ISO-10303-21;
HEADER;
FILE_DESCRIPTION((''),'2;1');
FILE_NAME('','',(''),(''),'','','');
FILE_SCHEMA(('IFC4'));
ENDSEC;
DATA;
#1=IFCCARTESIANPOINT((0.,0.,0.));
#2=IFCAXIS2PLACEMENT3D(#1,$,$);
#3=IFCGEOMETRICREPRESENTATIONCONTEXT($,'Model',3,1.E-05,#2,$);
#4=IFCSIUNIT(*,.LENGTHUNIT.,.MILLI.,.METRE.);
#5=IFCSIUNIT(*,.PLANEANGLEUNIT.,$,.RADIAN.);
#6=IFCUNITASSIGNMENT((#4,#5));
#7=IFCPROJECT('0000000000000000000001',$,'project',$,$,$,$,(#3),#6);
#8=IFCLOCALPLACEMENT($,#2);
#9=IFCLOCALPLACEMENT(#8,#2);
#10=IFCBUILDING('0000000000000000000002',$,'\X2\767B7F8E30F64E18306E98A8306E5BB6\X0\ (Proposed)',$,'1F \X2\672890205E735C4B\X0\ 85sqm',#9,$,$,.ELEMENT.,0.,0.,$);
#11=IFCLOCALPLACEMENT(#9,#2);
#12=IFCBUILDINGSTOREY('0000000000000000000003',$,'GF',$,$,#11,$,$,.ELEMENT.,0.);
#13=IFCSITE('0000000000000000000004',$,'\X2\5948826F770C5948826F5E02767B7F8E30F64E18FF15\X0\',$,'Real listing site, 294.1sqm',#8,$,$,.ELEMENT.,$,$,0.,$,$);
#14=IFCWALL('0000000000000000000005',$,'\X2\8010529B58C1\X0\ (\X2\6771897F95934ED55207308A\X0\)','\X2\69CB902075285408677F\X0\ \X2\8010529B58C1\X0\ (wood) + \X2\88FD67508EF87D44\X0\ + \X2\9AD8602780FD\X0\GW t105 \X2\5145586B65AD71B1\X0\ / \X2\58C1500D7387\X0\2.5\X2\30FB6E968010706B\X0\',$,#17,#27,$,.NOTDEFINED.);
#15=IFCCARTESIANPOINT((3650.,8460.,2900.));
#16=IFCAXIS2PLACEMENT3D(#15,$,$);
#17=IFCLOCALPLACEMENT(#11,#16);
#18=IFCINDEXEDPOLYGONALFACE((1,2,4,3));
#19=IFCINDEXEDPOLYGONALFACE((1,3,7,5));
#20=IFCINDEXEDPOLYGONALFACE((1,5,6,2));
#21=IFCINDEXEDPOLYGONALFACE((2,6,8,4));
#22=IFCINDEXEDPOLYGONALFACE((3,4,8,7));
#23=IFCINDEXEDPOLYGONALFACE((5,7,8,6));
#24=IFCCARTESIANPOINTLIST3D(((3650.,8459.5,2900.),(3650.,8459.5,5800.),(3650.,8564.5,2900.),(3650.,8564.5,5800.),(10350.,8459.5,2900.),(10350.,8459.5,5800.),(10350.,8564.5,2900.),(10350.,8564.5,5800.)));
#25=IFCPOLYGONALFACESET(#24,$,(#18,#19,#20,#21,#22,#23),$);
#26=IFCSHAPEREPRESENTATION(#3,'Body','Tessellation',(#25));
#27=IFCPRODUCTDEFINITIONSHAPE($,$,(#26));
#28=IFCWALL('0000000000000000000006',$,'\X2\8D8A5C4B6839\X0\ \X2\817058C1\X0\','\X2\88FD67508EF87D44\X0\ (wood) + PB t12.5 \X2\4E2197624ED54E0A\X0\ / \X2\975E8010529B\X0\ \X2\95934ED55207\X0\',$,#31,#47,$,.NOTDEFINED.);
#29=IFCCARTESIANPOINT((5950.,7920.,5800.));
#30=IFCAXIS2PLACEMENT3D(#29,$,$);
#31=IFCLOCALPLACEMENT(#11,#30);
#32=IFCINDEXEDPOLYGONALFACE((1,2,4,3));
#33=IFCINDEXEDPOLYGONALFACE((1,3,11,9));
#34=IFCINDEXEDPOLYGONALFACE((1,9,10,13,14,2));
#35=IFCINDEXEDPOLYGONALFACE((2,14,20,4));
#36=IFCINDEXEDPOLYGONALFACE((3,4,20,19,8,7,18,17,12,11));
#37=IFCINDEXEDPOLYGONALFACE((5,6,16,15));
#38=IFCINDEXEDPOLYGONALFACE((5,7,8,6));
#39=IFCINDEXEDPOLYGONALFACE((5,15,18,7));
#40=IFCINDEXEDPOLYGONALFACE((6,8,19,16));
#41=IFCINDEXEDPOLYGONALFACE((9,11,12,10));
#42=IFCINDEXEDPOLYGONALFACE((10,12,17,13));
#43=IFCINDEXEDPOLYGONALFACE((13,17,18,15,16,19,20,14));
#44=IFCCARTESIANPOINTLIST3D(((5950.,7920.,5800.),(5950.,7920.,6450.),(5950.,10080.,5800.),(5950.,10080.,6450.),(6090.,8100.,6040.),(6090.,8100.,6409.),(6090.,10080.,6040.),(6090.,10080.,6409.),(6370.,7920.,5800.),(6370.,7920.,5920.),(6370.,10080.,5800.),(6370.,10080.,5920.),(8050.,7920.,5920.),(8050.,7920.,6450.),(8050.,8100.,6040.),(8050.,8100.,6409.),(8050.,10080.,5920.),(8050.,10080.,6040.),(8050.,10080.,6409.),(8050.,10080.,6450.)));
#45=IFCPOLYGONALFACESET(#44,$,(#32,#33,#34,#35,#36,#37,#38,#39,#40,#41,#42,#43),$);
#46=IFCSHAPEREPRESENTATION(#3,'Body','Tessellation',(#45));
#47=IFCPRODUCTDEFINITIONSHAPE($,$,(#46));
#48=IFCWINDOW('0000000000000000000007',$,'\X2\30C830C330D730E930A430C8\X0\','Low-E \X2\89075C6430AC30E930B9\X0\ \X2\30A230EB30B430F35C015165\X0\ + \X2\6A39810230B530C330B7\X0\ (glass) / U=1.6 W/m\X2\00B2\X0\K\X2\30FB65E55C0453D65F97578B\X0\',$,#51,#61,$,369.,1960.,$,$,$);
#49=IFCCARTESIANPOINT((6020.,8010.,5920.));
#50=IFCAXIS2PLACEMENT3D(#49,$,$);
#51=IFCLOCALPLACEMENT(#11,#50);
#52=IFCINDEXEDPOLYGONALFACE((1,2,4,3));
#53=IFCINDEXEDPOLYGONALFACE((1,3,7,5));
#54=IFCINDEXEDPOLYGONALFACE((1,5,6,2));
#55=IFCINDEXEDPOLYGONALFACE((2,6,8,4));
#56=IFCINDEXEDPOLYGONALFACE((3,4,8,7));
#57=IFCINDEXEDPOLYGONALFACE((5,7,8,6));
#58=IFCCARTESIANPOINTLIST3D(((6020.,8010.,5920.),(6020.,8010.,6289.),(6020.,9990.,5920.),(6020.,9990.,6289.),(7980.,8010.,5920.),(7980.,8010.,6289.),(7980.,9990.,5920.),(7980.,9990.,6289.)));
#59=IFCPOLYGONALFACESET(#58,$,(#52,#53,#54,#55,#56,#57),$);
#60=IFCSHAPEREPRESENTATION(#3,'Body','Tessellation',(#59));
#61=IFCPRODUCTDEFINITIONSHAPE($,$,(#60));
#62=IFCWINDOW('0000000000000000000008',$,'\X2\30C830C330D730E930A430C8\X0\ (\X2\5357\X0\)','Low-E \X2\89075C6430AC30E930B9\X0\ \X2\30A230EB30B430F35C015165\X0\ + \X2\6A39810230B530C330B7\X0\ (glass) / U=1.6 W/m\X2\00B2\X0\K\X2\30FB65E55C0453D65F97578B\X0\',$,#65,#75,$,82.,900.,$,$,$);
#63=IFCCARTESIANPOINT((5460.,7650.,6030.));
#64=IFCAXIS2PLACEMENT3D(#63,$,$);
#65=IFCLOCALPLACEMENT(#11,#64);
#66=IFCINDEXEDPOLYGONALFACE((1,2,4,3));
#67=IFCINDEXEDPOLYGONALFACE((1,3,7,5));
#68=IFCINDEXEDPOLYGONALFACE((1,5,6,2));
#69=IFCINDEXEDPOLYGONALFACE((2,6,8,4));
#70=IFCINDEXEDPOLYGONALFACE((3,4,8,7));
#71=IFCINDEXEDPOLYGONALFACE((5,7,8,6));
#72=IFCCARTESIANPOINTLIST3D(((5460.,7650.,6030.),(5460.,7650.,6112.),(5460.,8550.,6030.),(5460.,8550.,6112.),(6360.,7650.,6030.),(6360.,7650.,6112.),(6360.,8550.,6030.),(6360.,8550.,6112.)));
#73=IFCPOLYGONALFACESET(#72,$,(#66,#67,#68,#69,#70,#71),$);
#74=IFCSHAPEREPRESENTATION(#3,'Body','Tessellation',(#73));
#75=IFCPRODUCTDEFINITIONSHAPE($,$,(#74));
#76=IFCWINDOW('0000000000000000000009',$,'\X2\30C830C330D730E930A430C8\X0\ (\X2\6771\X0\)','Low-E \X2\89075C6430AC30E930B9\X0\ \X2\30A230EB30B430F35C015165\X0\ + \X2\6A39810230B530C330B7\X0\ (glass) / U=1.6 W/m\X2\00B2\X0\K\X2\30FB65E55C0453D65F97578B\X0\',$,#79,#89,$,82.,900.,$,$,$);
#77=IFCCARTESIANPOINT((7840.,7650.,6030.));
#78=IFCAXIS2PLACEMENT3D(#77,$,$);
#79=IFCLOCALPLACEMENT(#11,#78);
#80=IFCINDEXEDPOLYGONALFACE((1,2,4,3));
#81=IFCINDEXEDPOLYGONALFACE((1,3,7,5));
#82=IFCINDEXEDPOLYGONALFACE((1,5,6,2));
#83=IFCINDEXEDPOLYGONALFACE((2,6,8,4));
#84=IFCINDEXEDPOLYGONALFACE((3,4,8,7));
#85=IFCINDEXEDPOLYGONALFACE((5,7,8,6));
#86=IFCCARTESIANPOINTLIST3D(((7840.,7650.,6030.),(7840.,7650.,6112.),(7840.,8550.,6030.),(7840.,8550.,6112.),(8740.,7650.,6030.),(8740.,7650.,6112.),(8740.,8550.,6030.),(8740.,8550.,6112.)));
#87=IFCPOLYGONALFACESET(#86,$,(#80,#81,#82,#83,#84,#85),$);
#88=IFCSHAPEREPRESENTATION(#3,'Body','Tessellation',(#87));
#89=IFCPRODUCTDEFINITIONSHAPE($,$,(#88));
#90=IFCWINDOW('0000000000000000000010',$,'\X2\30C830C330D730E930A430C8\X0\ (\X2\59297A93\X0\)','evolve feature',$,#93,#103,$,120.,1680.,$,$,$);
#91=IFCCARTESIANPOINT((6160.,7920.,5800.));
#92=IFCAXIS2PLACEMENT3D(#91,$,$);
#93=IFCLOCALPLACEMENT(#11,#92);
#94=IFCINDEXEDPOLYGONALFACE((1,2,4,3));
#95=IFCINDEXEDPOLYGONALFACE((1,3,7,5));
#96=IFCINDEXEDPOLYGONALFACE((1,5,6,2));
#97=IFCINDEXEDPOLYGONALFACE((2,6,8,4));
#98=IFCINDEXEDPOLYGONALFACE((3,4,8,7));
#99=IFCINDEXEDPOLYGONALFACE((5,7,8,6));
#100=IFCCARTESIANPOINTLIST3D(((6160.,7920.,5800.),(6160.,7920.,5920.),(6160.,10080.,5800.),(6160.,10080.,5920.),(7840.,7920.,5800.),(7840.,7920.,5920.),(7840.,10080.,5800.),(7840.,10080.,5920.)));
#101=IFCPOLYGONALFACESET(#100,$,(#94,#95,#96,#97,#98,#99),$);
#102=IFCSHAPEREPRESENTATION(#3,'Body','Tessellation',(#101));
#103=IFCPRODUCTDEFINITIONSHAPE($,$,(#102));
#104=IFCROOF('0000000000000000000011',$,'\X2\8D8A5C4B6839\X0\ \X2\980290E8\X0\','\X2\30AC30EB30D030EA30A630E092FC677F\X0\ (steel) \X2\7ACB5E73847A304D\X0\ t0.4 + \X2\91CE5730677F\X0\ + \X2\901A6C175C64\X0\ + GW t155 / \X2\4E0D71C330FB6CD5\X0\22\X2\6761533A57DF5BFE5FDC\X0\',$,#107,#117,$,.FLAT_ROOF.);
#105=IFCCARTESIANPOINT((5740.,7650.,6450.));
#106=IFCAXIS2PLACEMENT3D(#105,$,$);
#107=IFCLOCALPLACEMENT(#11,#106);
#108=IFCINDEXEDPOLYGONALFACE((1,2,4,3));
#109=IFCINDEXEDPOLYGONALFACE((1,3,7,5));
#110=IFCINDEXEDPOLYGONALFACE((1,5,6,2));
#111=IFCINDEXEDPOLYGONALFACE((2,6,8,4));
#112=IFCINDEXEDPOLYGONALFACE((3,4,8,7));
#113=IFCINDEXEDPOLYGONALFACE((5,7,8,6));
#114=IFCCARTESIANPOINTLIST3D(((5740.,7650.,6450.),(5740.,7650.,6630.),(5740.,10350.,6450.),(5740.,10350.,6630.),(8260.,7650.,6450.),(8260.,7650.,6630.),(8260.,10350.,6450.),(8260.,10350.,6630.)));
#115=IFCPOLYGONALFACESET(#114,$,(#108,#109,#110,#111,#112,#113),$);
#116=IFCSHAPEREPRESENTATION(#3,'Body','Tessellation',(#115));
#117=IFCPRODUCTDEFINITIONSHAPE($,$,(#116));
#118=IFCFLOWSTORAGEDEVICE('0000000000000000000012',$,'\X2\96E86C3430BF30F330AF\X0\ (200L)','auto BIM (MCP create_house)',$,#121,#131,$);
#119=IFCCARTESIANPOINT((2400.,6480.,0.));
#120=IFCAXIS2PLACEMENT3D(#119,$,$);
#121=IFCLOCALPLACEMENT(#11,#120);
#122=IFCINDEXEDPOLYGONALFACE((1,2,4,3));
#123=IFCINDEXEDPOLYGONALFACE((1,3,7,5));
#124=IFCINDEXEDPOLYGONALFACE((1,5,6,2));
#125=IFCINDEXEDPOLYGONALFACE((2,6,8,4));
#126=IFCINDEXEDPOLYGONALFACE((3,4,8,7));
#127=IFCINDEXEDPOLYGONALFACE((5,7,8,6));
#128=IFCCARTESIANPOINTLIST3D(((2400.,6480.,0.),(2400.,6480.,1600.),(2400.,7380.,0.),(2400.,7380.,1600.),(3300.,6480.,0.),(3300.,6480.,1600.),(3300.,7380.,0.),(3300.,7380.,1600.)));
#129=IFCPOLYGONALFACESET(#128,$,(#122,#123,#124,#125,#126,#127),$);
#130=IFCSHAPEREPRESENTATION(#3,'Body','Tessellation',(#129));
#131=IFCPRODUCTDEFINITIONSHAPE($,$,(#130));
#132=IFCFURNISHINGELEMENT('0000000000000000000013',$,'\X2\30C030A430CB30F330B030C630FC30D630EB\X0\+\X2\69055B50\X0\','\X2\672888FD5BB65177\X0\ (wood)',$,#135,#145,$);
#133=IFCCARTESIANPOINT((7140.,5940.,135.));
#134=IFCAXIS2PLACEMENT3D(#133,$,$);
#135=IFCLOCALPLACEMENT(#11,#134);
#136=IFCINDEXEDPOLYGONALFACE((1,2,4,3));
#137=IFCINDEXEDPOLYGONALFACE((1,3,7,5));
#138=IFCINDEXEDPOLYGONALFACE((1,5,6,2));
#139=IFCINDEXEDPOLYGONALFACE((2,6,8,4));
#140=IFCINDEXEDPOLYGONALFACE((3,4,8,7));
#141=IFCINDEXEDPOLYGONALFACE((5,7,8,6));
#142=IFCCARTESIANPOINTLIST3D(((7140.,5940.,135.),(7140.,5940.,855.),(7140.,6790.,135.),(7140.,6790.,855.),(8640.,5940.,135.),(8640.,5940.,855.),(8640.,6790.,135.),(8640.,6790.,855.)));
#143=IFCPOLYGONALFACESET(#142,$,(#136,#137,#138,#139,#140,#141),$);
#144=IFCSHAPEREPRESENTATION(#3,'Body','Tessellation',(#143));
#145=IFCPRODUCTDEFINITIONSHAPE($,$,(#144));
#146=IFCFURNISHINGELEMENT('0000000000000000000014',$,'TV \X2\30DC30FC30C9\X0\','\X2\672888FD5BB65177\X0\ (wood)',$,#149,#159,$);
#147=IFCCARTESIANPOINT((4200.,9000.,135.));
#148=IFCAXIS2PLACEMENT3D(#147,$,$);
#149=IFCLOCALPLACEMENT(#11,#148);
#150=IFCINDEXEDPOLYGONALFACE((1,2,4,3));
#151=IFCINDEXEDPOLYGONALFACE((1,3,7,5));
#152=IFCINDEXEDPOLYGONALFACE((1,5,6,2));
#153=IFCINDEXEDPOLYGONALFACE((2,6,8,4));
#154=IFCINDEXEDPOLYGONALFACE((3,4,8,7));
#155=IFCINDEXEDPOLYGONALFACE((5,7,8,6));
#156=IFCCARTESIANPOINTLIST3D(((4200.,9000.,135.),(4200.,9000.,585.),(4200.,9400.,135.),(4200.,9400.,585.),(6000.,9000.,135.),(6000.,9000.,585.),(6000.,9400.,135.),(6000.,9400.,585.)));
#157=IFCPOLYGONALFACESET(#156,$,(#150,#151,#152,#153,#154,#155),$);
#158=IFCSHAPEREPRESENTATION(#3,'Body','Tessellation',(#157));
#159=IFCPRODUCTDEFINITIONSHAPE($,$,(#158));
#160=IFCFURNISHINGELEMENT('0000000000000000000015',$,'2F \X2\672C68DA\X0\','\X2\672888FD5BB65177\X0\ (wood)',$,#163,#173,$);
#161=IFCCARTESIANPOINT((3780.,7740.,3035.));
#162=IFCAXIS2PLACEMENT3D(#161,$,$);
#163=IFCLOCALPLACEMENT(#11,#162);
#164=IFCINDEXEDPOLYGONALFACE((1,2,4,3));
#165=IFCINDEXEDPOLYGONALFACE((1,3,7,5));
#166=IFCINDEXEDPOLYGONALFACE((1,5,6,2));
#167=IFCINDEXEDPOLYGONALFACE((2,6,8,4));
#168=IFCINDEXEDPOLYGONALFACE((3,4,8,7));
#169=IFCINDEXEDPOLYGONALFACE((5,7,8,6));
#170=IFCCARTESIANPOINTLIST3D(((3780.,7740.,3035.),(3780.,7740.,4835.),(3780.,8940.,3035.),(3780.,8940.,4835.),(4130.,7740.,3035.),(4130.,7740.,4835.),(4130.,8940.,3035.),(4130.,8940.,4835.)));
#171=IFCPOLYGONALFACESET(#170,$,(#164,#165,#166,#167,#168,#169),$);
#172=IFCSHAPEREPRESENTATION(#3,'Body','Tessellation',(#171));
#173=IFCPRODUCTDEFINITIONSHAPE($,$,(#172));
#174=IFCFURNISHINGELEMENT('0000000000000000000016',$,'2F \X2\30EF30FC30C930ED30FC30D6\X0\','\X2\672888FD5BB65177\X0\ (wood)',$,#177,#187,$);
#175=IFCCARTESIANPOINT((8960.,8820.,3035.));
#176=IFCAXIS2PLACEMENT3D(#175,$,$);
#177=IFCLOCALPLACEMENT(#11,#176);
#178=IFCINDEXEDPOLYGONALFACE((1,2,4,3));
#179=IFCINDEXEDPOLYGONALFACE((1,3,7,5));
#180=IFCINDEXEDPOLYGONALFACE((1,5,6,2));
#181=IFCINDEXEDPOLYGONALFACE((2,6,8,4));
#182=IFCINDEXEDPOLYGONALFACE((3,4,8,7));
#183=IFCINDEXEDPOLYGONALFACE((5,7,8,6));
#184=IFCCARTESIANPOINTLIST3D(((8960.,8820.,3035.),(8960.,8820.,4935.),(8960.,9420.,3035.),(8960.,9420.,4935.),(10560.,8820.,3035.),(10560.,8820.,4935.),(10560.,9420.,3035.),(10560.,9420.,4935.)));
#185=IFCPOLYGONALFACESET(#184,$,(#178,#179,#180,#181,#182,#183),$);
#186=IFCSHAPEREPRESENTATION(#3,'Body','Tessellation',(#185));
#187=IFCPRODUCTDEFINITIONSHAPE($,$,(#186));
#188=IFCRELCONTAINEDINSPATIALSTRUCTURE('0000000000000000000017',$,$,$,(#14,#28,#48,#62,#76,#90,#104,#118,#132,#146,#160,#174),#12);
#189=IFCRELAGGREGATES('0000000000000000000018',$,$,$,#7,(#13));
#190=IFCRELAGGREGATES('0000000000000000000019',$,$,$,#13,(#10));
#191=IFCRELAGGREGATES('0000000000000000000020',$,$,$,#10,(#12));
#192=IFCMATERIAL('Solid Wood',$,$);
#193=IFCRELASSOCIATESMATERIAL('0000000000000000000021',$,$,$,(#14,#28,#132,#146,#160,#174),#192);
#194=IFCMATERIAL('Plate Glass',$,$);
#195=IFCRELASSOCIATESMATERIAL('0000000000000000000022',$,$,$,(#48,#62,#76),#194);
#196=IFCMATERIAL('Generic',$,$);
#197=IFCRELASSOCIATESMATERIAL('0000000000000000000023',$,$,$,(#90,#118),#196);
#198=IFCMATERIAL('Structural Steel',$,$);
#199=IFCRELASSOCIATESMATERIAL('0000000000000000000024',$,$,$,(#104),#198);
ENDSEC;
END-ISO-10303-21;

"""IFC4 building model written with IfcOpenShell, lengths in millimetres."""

from ifc_helpers import new_model, si_unit, frame, frame_2d, origin, place, context, project, spatial, rectangle, extrude, material, element, fill, save


model = new_model("IFC4")

# Units and contexts
model_context = context("Model", 3, precision=1e-05, world=origin())
ifc_project = project(units=[si_unit("LENGTHUNIT", "METRE", prefix="MILLI"), si_unit("PLANEANGLEUNIT", "RADIAN")], contexts=[model_context])

# Site, building, storey
site_placement = place(None, origin())
site = spatial("IfcSite", under=ifc_project, at=site_placement, Name="奈良県奈良市登美ヶ丘５", ObjectType="Real listing site, 294.1sqm", CompositionType="ELEMENT", RefElevation=0.0)
building_placement = place(site_placement, origin())
building = spatial("IfcBuilding", under=site, at=building_placement, Name="登美ヶ丘の風の家 (Proposed)", ObjectType="1F 木造平屋 85sqm", CompositionType="ELEMENT", ElevationOfRefHeight=0.0, ElevationOfTerrain=0.0)
storey_placement = place(building_placement, origin())
storey = spatial("IfcBuildingStorey", under=building, at=storey_placement, Name="GF", CompositionType="ELEMENT", Elevation=0.0)

# Wall
ifc_material_1 = material(Name="Solid Wood")
wall_1_placement = place(storey_placement, frame((3650.0, 8460.0, 2900.0)))
element("IfcWall", 1, at=wall_1_placement, inside=storey, material=ifc_material_1, Name="耐力壁 (東西間仕切り)", Description="構造用合板 耐力壁 (wood) + 製材軸組 + 高性能GW t105 充填断熱 / 壁倍率2.5・準耐火", PredefinedType="NOTDEFINED", context=model_context, shape_type="SweptSolid", body=[
    extrude(rectangle(XDim=6700.0, YDim=105.0, at=frame_2d((3350.0, 52.0))), frame((3650.0, 8460.0, 2900.0)), (0.0, 0.0, 1.0), 2900.0),
])

# Wall, openings, windows
wall_2_placement = place(storey_placement, frame((5950.0, 7920.0, 5800.0)))
wall_2 = element("IfcWall", 2, at=wall_2_placement, inside=storey, material=ifc_material_1, Name="越屋根 腰壁", Description="製材軸組 (wood) + PB t12.5 両面仕上 / 非耐力 間仕切", PredefinedType="NOTDEFINED", context=model_context, shape_type="SweptSolid", body=[
    extrude(rectangle(XDim=2100.0, YDim=2160.0, at=frame_2d((1050.0, 1080.0))), frame((5950.0, 7920.0, 5800.0)), (0.0, 0.0, 1.0), 650.0),
])
opening_1_placement = place(storey_placement, frame((6020.0, 8010.0, 5920.0)))
opening_1 = element("IfcOpeningElement", 3, at=opening_1_placement, cuts=wall_2, PredefinedType="NOTDEFINED", context=model_context, shape_type="SweptSolid", body=[
    extrude(rectangle(XDim=1960.0, YDim=1980.0, at=frame_2d((980.0, 990.0))), frame((6020.0, 8010.0, 5920.0)), (0.0, 0.0, 1.0), 369.0),
])
opening_2_placement = place(storey_placement, frame((5460.0, 7650.0, 6030.0)))
opening_2 = element("IfcOpeningElement", 4, at=opening_2_placement, cuts=wall_2, PredefinedType="NOTDEFINED", context=model_context, shape_type="SweptSolid", body=[
    extrude(rectangle(XDim=900.0, YDim=900.0, at=frame_2d((450.0, 450.0))), frame((5460.0, 7650.0, 6030.0)), (0.0, 0.0, 1.0), 82.0),
])
opening_3_placement = place(storey_placement, frame((7840.0, 7650.0, 6030.0)))
opening_3 = element("IfcOpeningElement", 5, at=opening_3_placement, cuts=wall_2, PredefinedType="NOTDEFINED", context=model_context, shape_type="SweptSolid", body=[
    extrude(rectangle(XDim=900.0, YDim=900.0, at=frame_2d((450.0, 450.0))), frame((7840.0, 7650.0, 6030.0)), (0.0, 0.0, 1.0), 82.0),
])
opening_4_placement = place(storey_placement, frame((6160.0, 7920.0, 5800.0)))
opening_4 = element("IfcOpeningElement", 6, at=opening_4_placement, cuts=wall_2, PredefinedType="NOTDEFINED", context=model_context, shape_type="SweptSolid", body=[
    extrude(rectangle(XDim=1680.0, YDim=2160.0, at=frame_2d((840.0, 1080.0))), frame((6160.0, 7920.0, 5800.0)), (0.0, 0.0, 1.0), 120.0),
])
ifc_material_2 = material(Name="Plate Glass")
window_1_placement = place(storey_placement, frame((6020.0, 8010.0, 5920.0)))
window_1 = element("IfcWindow", 7, at=window_1_placement, inside=storey, material=ifc_material_2, Name="トップライト", Description="Low-E 複層ガラス アルゴン封入 + 樹脂サッシ (glass) / U=1.6 W/m²K・日射取得型", OverallHeight=369.0, OverallWidth=1960.0, context=model_context, shape_type="SweptSolid", body=[
    extrude(rectangle(XDim=1960.0, YDim=1980.0, at=frame_2d((980.0, 990.0))), frame((6020.0, 8010.0, 5920.0)), (0.0, 0.0, 1.0), 369.0),
])
fill(opening_1, window_1)
window_2_placement = place(storey_placement, frame((5460.0, 7650.0, 6030.0)))
window_2 = element("IfcWindow", 8, at=window_2_placement, inside=storey, material=ifc_material_2, Name="トップライト (南)", Description="Low-E 複層ガラス アルゴン封入 + 樹脂サッシ (glass) / U=1.6 W/m²K・日射取得型", OverallHeight=82.0, OverallWidth=900.0, context=model_context, shape_type="SweptSolid", body=[
    extrude(rectangle(XDim=900.0, YDim=900.0, at=frame_2d((450.0, 450.0))), frame((5460.0, 7650.0, 6030.0)), (0.0, 0.0, 1.0), 82.0),
])
fill(opening_2, window_2)
window_3_placement = place(storey_placement, frame((7840.0, 7650.0, 6030.0)))
window_3 = element("IfcWindow", 9, at=window_3_placement, inside=storey, material=ifc_material_2, Name="トップライト (東)", Description="Low-E 複層ガラス アルゴン封入 + 樹脂サッシ (glass) / U=1.6 W/m²K・日射取得型", OverallHeight=82.0, OverallWidth=900.0, context=model_context, shape_type="SweptSolid", body=[
    extrude(rectangle(XDim=900.0, YDim=900.0, at=frame_2d((450.0, 450.0))), frame((7840.0, 7650.0, 6030.0)), (0.0, 0.0, 1.0), 82.0),
])
fill(opening_3, window_3)
ifc_material_3 = material(Name="Generic")
window_4_placement = place(storey_placement, frame((6160.0, 7920.0, 5800.0)))
window_4 = element("IfcWindow", 10, at=window_4_placement, inside=storey, material=ifc_material_3, Name="トップライト (天窓)", Description="evolve feature", OverallHeight=120.0, OverallWidth=1680.0, context=model_context, shape_type="SweptSolid", body=[
    extrude(rectangle(XDim=1680.0, YDim=2160.0, at=frame_2d((840.0, 1080.0))), frame((6160.0, 7920.0, 5800.0)), (0.0, 0.0, 1.0), 120.0),
])
fill(opening_4, window_4)

# Roof
ifc_material_4 = material(Name="Structural Steel")
roof_placement = place(storey_placement, frame((5740.0, 7650.0, 6450.0)))
element("IfcRoof", 11, at=roof_placement, inside=storey, material=ifc_material_4, Name="越屋根 頂部", Description="ガルバリウム鋼板 (steel) 立平葺き t0.4 + 野地板 + 通気層 + GW t155 / 不燃・法22条区域対応", PredefinedType="FLAT_ROOF", context=model_context, shape_type="SweptSolid", body=[
    extrude(rectangle(XDim=2520.0, YDim=2700.0, at=frame_2d((1260.0, 1350.0))), frame((5740.0, 7650.0, 6450.0)), (0.0, 0.0, 1.0), 180.0),
])

# Flow storage device
flow_storage_device_placement = place(storey_placement, frame((2400.0, 6480.0, 0.0)))
element("IfcFlowStorageDevice", 12, at=flow_storage_device_placement, inside=storey, material=ifc_material_3, Name="雨水タンク (200L)", Description="auto BIM (MCP create_house)", context=model_context, shape_type="SweptSolid", body=[
    extrude(rectangle(XDim=900.0, YDim=900.0, at=frame_2d((450.0, 450.0))), frame((2400.0, 6480.0, 0.0)), (0.0, 0.0, 1.0), 1600.0),
])

# Furnishing elements
furnishing_1_placement = place(storey_placement, frame((7140.0, 5940.0, 135.0)))
element("IfcFurnishingElement", 13, at=furnishing_1_placement, inside=storey, material=ifc_material_1, Name="ダイニングテーブル+椅子", Description="木製家具 (wood)", context=model_context, shape_type="SweptSolid", body=[
    extrude(rectangle(XDim=1500.0, YDim=850.0, at=frame_2d((750.0, 425.0))), frame((7140.0, 5940.0, 135.0)), (0.0, 0.0, 1.0), 720.0),
])
furnishing_2_placement = place(storey_placement, frame((4200.0, 9000.0, 135.0)))
element("IfcFurnishingElement", 14, at=furnishing_2_placement, inside=storey, material=ifc_material_1, Name="TV ボード", Description="木製家具 (wood)", context=model_context, shape_type="SweptSolid", body=[
    extrude(rectangle(XDim=1800.0, YDim=400.0, at=frame_2d((900.0, 200.0))), frame((4200.0, 9000.0, 135.0)), (0.0, 0.0, 1.0), 450.0),
])
furnishing_3_placement = place(storey_placement, frame((3780.0, 7740.0, 3035.0)))
element("IfcFurnishingElement", 15, at=furnishing_3_placement, inside=storey, material=ifc_material_1, Name="2F 本棚", Description="木製家具 (wood)", context=model_context, shape_type="SweptSolid", body=[
    extrude(rectangle(XDim=350.0, YDim=1200.0, at=frame_2d((175.0, 600.0))), frame((3780.0, 7740.0, 3035.0)), (0.0, 0.0, 1.0), 1800.0),
])
furnishing_4_placement = place(storey_placement, frame((8960.0, 8820.0, 3035.0)))
element("IfcFurnishingElement", 16, at=furnishing_4_placement, inside=storey, material=ifc_material_1, Name="2F ワードローブ", Description="木製家具 (wood)", context=model_context, shape_type="SweptSolid", body=[
    extrude(rectangle(XDim=1600.0, YDim=600.0, at=frame_2d((800.0, 300.0))), frame((8960.0, 8820.0, 3035.0)), (0.0, 0.0, 1.0), 1900.0),
])

save(model, "model.ifc")
